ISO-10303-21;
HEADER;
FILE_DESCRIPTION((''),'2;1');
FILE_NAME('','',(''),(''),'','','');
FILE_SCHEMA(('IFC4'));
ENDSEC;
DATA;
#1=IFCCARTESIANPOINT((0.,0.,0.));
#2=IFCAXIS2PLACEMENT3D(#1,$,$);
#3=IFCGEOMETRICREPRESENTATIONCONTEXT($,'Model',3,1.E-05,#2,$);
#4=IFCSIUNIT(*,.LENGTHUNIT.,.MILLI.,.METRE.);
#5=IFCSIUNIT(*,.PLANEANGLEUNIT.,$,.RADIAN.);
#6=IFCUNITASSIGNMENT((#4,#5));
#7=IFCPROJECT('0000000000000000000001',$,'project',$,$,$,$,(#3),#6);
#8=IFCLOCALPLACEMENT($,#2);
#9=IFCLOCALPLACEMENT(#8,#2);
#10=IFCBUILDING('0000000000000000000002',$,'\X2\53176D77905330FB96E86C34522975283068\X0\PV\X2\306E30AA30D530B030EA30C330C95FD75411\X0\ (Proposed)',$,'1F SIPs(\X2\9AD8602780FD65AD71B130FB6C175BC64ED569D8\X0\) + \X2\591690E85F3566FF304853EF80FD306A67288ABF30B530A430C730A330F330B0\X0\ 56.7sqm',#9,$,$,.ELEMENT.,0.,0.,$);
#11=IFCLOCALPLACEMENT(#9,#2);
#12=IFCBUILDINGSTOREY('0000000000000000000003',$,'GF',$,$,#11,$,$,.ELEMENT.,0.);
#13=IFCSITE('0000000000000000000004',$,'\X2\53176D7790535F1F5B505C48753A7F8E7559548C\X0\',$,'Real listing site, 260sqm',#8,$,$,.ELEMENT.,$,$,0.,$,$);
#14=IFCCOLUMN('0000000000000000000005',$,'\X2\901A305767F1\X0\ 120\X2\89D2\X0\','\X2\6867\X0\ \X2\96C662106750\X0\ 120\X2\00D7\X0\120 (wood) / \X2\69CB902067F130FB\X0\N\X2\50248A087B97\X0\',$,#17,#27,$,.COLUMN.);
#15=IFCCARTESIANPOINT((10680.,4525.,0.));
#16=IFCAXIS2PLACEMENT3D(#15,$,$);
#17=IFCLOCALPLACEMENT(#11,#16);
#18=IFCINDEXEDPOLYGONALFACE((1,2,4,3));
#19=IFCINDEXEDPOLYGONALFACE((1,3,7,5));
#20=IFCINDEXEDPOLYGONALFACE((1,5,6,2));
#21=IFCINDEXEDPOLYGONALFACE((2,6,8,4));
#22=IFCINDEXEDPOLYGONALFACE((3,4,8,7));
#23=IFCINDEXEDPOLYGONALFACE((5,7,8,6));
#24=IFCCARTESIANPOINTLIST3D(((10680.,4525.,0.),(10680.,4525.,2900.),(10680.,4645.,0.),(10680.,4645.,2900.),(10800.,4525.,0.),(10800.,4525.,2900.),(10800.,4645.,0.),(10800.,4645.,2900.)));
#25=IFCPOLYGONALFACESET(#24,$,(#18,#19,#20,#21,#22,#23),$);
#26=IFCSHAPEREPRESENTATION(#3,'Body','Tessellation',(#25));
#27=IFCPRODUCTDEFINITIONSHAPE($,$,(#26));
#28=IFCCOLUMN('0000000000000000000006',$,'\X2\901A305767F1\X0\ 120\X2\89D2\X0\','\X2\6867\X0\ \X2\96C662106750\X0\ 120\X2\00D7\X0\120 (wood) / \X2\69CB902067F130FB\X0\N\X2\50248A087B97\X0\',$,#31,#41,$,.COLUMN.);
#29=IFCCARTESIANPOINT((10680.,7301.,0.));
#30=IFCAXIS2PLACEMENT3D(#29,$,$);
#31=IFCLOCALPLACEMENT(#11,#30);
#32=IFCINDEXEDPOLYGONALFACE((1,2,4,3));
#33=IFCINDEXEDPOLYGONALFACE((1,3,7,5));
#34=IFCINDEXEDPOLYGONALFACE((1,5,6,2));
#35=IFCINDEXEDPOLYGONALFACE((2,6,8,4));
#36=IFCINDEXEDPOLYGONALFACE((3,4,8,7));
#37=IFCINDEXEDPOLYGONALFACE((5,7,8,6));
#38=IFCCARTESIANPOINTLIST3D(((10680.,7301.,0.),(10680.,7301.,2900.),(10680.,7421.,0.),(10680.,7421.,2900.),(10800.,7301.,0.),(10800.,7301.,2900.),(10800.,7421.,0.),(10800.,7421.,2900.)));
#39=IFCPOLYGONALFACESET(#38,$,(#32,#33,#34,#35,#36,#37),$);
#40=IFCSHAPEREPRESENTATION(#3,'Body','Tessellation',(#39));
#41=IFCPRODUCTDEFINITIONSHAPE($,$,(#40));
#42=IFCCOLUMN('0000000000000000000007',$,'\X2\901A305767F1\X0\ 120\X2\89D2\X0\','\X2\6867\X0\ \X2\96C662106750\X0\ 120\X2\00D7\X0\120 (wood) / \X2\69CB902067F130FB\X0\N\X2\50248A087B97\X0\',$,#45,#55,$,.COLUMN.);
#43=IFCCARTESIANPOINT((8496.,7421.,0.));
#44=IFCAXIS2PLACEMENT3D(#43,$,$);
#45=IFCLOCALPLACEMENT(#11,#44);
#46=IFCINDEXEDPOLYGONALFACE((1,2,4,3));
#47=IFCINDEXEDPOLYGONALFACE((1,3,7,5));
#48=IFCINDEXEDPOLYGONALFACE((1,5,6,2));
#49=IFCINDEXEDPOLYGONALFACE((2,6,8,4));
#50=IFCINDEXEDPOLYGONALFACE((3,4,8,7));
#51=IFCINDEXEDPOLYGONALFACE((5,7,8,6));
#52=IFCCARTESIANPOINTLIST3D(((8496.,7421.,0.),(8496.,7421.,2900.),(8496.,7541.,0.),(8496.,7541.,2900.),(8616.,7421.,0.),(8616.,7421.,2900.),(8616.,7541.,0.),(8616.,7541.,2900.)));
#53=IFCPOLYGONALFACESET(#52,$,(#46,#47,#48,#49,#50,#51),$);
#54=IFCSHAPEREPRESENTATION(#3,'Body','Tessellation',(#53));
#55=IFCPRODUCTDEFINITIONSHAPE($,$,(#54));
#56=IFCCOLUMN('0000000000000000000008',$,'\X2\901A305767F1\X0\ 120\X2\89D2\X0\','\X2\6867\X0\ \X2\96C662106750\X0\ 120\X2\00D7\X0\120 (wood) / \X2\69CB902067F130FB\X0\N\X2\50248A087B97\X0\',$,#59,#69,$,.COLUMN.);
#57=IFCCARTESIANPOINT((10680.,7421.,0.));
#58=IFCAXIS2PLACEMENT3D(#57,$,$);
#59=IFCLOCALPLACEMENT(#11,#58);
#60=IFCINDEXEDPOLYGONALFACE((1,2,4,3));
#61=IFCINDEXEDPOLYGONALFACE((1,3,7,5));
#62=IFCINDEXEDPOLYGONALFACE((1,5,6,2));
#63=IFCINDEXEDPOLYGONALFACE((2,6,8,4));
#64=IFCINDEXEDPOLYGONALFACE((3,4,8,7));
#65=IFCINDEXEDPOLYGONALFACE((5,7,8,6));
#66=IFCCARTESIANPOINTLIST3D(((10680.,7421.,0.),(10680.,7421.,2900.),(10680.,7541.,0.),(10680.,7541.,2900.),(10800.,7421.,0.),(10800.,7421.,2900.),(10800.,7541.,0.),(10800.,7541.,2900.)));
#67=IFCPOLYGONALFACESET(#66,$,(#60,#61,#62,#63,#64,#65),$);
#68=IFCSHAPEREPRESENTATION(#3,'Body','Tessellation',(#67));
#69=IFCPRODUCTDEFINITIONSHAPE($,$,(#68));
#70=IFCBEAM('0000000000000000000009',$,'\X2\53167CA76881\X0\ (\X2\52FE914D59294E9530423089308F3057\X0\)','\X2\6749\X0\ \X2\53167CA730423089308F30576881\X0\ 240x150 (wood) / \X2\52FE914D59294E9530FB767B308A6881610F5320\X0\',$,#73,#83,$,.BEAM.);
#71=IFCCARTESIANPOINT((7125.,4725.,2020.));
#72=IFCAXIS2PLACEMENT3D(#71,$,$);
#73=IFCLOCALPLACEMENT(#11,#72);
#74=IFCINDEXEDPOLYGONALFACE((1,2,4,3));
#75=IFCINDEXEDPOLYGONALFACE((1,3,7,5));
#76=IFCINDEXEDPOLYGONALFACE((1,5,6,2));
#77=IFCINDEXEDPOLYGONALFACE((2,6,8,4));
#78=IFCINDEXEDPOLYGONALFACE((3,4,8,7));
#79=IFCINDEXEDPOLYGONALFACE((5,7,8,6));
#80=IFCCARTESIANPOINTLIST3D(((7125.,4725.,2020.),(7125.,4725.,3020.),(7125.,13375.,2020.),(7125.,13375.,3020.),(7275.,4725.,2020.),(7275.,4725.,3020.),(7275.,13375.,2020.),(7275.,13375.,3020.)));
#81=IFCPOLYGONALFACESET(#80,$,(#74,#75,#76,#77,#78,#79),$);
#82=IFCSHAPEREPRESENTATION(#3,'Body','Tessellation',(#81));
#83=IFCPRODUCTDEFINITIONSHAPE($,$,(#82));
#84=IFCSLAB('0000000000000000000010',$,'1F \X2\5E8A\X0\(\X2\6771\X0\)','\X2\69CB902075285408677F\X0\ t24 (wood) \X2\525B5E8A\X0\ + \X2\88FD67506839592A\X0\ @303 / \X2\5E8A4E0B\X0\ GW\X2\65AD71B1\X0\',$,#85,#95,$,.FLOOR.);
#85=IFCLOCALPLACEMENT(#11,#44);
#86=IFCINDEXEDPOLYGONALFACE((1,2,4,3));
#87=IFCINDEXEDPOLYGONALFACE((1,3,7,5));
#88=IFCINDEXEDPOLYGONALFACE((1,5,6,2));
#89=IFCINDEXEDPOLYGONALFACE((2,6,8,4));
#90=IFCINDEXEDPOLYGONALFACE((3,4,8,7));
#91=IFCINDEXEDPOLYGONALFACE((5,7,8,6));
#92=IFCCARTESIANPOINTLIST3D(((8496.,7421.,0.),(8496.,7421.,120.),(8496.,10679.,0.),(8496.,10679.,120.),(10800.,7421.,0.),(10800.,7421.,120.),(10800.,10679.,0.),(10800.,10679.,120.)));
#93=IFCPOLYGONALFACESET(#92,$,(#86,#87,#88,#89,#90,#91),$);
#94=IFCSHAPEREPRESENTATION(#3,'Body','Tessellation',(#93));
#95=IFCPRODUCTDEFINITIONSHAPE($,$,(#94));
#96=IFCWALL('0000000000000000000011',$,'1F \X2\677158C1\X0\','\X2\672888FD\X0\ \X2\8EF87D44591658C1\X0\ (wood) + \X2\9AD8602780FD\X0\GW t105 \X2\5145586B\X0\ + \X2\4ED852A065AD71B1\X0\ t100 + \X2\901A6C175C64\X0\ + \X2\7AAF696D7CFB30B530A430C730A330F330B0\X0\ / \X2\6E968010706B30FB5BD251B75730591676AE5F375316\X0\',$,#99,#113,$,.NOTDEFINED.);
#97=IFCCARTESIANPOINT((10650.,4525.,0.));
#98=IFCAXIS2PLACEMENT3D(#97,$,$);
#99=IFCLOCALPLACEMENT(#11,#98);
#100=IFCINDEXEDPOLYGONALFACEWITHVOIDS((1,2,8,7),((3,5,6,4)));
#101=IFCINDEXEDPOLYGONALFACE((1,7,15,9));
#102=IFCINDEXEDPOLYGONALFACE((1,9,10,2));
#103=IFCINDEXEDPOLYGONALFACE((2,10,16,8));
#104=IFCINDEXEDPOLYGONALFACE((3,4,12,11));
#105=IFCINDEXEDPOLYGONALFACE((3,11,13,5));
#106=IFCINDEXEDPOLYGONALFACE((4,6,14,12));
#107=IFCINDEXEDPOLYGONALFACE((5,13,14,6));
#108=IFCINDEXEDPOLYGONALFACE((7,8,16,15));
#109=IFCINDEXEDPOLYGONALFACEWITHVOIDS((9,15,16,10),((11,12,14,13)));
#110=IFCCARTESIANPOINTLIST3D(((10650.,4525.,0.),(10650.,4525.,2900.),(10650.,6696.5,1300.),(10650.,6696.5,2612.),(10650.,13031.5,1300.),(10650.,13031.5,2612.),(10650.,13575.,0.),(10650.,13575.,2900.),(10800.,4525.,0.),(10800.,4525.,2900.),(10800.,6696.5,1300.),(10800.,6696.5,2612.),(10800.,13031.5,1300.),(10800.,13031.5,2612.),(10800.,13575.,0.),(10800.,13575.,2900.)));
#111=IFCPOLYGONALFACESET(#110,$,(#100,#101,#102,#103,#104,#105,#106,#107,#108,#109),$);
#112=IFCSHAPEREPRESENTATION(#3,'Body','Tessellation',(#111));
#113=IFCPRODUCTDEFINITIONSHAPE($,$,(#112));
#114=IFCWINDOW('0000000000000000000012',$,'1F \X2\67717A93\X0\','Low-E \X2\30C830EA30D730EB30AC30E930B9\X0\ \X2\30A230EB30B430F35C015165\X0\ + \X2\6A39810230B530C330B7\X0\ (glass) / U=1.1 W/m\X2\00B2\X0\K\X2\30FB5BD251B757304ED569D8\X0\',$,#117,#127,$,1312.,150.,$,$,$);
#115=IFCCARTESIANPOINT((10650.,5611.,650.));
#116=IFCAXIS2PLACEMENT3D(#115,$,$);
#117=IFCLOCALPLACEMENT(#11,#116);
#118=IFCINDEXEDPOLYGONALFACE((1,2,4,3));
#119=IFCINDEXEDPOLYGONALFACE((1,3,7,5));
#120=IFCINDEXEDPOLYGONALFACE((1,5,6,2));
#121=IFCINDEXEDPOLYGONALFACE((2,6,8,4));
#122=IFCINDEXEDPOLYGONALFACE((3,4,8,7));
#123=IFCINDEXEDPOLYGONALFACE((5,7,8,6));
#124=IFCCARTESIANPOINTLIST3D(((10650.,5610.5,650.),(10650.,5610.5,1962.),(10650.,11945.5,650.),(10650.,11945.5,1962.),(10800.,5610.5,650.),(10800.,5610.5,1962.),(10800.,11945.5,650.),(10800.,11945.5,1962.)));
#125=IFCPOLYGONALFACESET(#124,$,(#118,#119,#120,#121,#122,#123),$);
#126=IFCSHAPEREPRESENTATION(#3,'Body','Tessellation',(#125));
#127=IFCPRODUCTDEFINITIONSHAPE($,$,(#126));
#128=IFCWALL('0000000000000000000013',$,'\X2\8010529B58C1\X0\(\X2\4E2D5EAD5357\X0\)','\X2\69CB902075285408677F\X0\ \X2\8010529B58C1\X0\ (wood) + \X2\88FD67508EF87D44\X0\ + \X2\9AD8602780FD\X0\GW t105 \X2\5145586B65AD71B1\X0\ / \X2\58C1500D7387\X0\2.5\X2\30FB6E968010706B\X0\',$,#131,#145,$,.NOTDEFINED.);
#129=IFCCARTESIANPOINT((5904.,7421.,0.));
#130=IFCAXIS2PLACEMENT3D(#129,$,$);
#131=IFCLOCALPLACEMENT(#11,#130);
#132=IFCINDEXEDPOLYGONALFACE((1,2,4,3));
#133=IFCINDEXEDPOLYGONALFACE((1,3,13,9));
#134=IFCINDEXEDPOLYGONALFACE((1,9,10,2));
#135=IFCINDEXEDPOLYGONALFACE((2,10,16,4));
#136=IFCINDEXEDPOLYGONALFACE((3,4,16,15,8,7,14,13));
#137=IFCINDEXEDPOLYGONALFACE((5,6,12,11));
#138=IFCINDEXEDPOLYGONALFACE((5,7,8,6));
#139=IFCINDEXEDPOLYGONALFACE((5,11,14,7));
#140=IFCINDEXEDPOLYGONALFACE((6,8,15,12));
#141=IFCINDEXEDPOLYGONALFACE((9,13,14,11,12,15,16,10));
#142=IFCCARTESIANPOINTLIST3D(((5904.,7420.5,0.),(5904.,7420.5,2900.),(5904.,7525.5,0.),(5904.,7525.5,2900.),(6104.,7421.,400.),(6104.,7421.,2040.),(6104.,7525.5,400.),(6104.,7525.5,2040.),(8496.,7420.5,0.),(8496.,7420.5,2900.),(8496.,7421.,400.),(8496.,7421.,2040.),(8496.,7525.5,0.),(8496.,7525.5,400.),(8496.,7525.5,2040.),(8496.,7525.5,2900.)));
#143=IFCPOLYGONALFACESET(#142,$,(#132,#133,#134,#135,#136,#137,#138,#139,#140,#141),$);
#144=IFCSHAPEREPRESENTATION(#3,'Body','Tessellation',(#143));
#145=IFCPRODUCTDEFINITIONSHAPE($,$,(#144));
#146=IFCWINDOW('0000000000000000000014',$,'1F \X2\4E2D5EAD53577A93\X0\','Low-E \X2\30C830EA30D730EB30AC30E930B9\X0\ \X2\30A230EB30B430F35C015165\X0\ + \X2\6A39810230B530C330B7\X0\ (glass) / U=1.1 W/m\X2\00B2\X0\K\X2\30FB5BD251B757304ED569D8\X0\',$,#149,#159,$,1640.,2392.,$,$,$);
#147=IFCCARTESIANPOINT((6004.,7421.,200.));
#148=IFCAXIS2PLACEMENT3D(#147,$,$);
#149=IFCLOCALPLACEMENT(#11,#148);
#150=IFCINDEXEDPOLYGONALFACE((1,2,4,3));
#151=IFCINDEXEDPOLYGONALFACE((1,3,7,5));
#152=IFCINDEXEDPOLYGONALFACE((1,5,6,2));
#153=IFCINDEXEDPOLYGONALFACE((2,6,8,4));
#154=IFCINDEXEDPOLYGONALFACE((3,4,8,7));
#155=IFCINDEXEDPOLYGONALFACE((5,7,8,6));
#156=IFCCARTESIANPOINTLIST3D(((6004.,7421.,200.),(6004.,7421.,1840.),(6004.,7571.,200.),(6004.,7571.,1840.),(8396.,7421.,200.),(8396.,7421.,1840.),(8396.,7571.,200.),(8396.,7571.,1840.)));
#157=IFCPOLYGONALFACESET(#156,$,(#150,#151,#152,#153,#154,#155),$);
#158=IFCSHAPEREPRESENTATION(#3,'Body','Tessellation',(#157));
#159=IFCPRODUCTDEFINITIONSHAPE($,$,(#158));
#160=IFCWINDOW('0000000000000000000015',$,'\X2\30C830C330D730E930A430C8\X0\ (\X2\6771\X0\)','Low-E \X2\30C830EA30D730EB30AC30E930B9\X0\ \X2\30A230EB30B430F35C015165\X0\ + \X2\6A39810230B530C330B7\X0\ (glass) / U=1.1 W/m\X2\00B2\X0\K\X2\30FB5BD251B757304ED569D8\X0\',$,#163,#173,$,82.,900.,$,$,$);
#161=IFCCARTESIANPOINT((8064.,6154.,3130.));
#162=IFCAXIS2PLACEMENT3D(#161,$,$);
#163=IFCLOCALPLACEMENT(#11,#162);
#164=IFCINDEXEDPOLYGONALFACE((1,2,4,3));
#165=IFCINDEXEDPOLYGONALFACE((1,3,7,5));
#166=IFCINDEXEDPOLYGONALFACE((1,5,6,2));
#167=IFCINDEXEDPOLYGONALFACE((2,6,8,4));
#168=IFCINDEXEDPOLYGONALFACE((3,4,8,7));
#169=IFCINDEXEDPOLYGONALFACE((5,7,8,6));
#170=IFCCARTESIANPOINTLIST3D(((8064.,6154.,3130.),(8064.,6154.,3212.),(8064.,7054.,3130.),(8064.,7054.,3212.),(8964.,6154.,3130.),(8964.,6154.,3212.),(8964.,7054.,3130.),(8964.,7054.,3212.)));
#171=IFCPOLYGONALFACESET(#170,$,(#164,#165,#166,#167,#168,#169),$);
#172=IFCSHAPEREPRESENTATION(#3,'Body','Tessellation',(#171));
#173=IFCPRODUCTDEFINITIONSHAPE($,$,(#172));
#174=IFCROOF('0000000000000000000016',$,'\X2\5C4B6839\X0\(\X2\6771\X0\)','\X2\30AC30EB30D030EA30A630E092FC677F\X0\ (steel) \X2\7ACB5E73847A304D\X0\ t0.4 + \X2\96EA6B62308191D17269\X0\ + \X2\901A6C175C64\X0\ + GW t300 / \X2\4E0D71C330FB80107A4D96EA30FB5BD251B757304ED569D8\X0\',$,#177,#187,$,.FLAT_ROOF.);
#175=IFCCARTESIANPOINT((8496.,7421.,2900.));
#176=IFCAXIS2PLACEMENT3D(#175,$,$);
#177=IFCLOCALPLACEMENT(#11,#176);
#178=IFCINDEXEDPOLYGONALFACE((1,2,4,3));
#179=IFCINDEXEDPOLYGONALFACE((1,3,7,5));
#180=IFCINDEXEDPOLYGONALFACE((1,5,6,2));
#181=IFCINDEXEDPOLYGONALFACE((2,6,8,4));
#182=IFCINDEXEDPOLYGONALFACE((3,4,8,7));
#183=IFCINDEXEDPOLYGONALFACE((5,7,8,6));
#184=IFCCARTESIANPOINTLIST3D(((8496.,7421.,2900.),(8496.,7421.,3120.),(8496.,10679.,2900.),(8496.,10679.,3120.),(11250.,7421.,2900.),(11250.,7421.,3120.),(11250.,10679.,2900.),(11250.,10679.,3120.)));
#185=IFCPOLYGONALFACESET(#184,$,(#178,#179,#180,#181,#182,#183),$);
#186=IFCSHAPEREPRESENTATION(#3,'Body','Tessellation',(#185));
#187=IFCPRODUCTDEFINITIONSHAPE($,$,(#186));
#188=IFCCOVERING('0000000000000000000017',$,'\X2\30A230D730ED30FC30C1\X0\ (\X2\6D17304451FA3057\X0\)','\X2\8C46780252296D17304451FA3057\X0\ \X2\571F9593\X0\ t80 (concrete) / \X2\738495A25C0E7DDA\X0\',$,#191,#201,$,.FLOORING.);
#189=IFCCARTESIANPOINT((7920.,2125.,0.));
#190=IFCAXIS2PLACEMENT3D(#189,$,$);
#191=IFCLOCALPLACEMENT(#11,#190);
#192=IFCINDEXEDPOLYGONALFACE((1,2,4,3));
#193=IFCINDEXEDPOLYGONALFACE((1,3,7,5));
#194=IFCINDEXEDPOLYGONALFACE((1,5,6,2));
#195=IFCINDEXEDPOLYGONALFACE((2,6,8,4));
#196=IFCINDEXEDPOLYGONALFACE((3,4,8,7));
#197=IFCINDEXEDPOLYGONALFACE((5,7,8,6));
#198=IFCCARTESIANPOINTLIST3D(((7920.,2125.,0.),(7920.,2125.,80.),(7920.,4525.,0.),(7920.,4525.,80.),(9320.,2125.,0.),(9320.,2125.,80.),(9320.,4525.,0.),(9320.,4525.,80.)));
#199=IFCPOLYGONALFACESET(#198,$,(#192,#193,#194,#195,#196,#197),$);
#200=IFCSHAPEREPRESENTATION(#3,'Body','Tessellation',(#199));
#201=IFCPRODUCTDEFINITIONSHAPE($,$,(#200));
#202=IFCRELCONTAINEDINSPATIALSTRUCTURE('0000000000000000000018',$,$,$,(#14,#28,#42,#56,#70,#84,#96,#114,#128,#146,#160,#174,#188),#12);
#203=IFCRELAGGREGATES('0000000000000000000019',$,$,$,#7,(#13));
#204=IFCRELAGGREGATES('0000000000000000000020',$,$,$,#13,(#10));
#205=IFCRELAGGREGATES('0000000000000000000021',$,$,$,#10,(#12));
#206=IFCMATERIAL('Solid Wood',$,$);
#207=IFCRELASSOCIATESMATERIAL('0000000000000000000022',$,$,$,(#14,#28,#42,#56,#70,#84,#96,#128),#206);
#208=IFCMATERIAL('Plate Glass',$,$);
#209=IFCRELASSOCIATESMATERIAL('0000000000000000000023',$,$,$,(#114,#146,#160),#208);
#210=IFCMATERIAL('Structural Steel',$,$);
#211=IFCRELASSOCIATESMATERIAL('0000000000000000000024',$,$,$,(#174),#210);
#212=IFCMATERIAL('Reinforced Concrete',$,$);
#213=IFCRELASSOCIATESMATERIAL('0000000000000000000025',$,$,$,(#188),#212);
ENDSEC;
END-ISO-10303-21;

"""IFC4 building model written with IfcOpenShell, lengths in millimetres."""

from ifc_helpers import new_model, si_unit, frame, frame_2d, origin, place, context, project, spatial, rectangle, extrude, material, element, fill, save


model = new_model("IFC4")

# Units and contexts
model_context = context("Model", 3, precision=1e-05, world=origin())
ifc_project = project(units=[si_unit("LENGTHUNIT", "METRE", prefix="MILLI"), si_unit("PLANEANGLEUNIT", "RADIAN")], contexts=[model_context])

# Site, building, storey
site_placement = place(None, origin())
site = spatial("IfcSite", under=ifc_project, at=site_placement, Name="北海道弟子屈町美留和", ObjectType="Real listing site, 260sqm", CompositionType="ELEMENT", RefElevation=0.0)
building_placement = place(site_placement, origin())
building = spatial("IfcBuilding", under=site, at=building_placement, Name="北海道・雨水利用とPVのオフグリッド志向 (Proposed)", ObjectType="1F SIPs(高性能断熱・気密仕様) + 外部張替え可能な木調サイディング 56.7sqm", CompositionType="ELEMENT", ElevationOfRefHeight=0.0, ElevationOfTerrain=0.0)
storey_placement = place(building_placement, origin())
storey = spatial("IfcBuildingStorey", under=building, at=storey_placement, Name="GF", CompositionType="ELEMENT", Elevation=0.0)

# Columns
ifc_material_1 = material(Name="Solid Wood")
column_1_placement = place(storey_placement, frame((10680.0, 4525.0, 0.0)))
element("IfcColumn", 1, at=column_1_placement, inside=storey, material=ifc_material_1, Name="通し柱 120角", Description="桧 集成材 120×120 (wood) / 構造柱・N値計算", PredefinedType="COLUMN", context=model_context, shape_type="SweptSolid", body=[
    extrude(rectangle(XDim=120.0, YDim=120.0, at=frame_2d((60.0, 60.0))), frame((10680.0, 4525.0, 0.0)), (0.0, 0.0, 1.0), 2900.0),
])
column_2_placement = place(storey_placement, frame((10680.0, 7301.0, 0.0)))
element("IfcColumn", 2, at=column_2_placement, inside=storey, material=ifc_material_1, Name="通し柱 120角", Description="桧 集成材 120×120 (wood) / 構造柱・N値計算", PredefinedType="COLUMN", context=model_context, shape_type="SweptSolid", body=[
    extrude(rectangle(XDim=120.0, YDim=120.0, at=frame_2d((60.0, 60.0))), frame((10680.0, 7301.0, 0.0)), (0.0, 0.0, 1.0), 2900.0),
])
column_3_placement = place(storey_placement, frame((8496.0, 7421.0, 0.0)))
element("IfcColumn", 3, at=column_3_placement, inside=storey, material=ifc_material_1, Name="通し柱 120角", Description="桧 集成材 120×120 (wood) / 構造柱・N値計算", PredefinedType="COLUMN", context=model_context, shape_type="SweptSolid", body=[
    extrude(rectangle(XDim=120.0, YDim=120.0, at=frame_2d((60.0, 60.0))), frame((8496.0, 7421.0, 0.0)), (0.0, 0.0, 1.0), 2900.0),
])
column_4_placement = place(storey_placement, frame((10680.0, 7421.0, 0.0)))
element("IfcColumn", 4, at=column_4_placement, inside=storey, material=ifc_material_1, Name="通し柱 120角", Description="桧 集成材 120×120 (wood) / 構造柱・N値計算", PredefinedType="COLUMN", context=model_context, shape_type="SweptSolid", body=[
    extrude(rectangle(XDim=120.0, YDim=120.0, at=frame_2d((60.0, 60.0))), frame((10680.0, 7421.0, 0.0)), (0.0, 0.0, 1.0), 2900.0),
])

# Beam
beam_1_placement = place(storey_placement, frame((7125.0, 4725.0, 2020.0)))
element("IfcBeam", 5, at=beam_1_placement, inside=storey, material=ifc_material_1, Name="化粧梁 (勾配天井あらわし)", Description="杉 化粧あらわし梁 240x150 (wood) / 勾配天井・登り梁意匠", PredefinedType="BEAM", context=model_context, shape_type="SweptSolid", body=[
    extrude(rectangle(XDim=150.0, YDim=8650.0, at=frame_2d((75.0, 4325.0))), frame((7125.0, 4725.0, 2020.0)), (0.0, 0.0, 1.0), 1000.0),
])

# Slab
slab_placement = place(storey_placement, frame((8496.0, 7421.0, 0.0)))
element("IfcSlab", 6, at=slab_placement, inside=storey, material=ifc_material_1, Name="1F 床(東)", Description="構造用合板 t24 (wood) 剛床 + 製材根太 @303 / 床下 GW断熱", PredefinedType="FLOOR", context=model_context, shape_type="SweptSolid", body=[
    extrude(rectangle(XDim=2304.0, YDim=3258.0, at=frame_2d((1152.0, 1629.0))), frame((8496.0, 7421.0, 0.0)), (0.0, 0.0, 1.0), 120.0),
])

# Walls, openings, windows
wall_1_placement = place(storey_placement, frame((10650.0, 4525.0, 0.0)))
wall_1 = element("IfcWall", 7, at=wall_1_placement, inside=storey, material=ifc_material_1, Name="1F 東壁", Description="木製 軸組外壁 (wood) + 高性能GW t105 充填 + 付加断熱 t100 + 通気層 + 窯業系サイディング / 準耐火・寒冷地外皮強化", PredefinedType="NOTDEFINED", context=model_context, shape_type="SweptSolid", body=[
    extrude(rectangle(XDim=150.0, YDim=9050.0, at=frame_2d((75.0, 4525.0))), frame((10650.0, 4525.0, 0.0)), (0.0, 0.0, 1.0), 2900.0),
])
opening_1_placement = place(storey_placement, frame((10650.0, 5611.0, 650.0)))
opening_1 = element("IfcOpeningElement", 8, at=opening_1_placement, cuts=wall_1, PredefinedType="NOTDEFINED", context=model_context, shape_type="SweptSolid", body=[
    extrude(rectangle(XDim=150.0, YDim=6335.0, at=frame_2d((75.0, 3167.0))), frame((10650.0, 5611.0, 650.0)), (0.0, 0.0, 1.0), 1312.0),
])
ifc_material_2 = material(Name="Plate Glass")
window_1_placement = place(storey_placement, frame((10650.0, 5611.0, 650.0)))
window_1 = element("IfcWindow", 9, at=window_1_placement, inside=storey, material=ifc_material_2, Name="1F 東窓", Description="Low-E トリプルガラス アルゴン封入 + 樹脂サッシ (glass) / U=1.1 W/m²K・寒冷地仕様", OverallHeight=1312.0, OverallWidth=150.0, context=model_context, shape_type="SweptSolid", body=[
    extrude(rectangle(XDim=150.0, YDim=6335.0, at=frame_2d((75.0, 3167.0))), frame((10650.0, 5611.0, 650.0)), (0.0, 0.0, 1.0), 1312.0),
])
fill(opening_1, window_1)
wall_2_placement = place(storey_placement, frame((5904.0, 7421.0, 0.0)))
wall_2 = element("IfcWall", 10, at=wall_2_placement, inside=storey, material=ifc_material_1, Name="耐力壁(中庭南)", Description="構造用合板 耐力壁 (wood) + 製材軸組 + 高性能GW t105 充填断熱 / 壁倍率2.5・準耐火", PredefinedType="NOTDEFINED", context=model_context, shape_type="SweptSolid", body=[
    extrude(rectangle(XDim=2592.0, YDim=105.0, at=frame_2d((1296.0, 52.0))), frame((5904.0, 7421.0, 0.0)), (0.0, 0.0, 1.0), 2900.0),
])
opening_2_placement = place(storey_placement, frame((6004.0, 7421.0, 200.0)))
opening_2 = element("IfcOpeningElement", 11, at=opening_2_placement, cuts=wall_2, PredefinedType="NOTDEFINED", context=model_context, shape_type="SweptSolid", body=[
    extrude(rectangle(XDim=2392.0, YDim=150.0, at=frame_2d((1196.0, 75.0))), frame((6004.0, 7421.0, 200.0)), (0.0, 0.0, 1.0), 1640.0),
])
window_2_placement = place(storey_placement, frame((6004.0, 7421.0, 200.0)))
window_2 = element("IfcWindow", 12, at=window_2_placement, inside=storey, material=ifc_material_2, Name="1F 中庭南窓", Description="Low-E トリプルガラス アルゴン封入 + 樹脂サッシ (glass) / U=1.1 W/m²K・寒冷地仕様", OverallHeight=1640.0, OverallWidth=2392.0, context=model_context, shape_type="SweptSolid", body=[
    extrude(rectangle(XDim=2392.0, YDim=150.0, at=frame_2d((1196.0, 75.0))), frame((6004.0, 7421.0, 200.0)), (0.0, 0.0, 1.0), 1640.0),
])
fill(opening_2, window_2)

# Window
window_3_placement = place(storey_placement, frame((8064.0, 6154.0, 3130.0)))
element("IfcWindow", 13, at=window_3_placement, inside=storey, material=ifc_material_2, Name="トップライト (東)", Description="Low-E トリプルガラス アルゴン封入 + 樹脂サッシ (glass) / U=1.1 W/m²K・寒冷地仕様", OverallHeight=82.0, OverallWidth=900.0, context=model_context, shape_type="SweptSolid", body=[
    extrude(rectangle(XDim=900.0, YDim=900.0, at=frame_2d((450.0, 450.0))), frame((8064.0, 6154.0, 3130.0)), (0.0, 0.0, 1.0), 82.0),
])

# Roof
ifc_material_3 = material(Name="Structural Steel")
roof_placement = place(storey_placement, frame((8496.0, 7421.0, 2900.0)))
element("IfcRoof", 14, at=roof_placement, inside=storey, material=ifc_material_3, Name="屋根(東)", Description="ガルバリウム鋼板 (steel) 立平葺き t0.4 + 雪止め金物 + 通気層 + GW t300 / 不燃・耐積雪・寒冷地仕様", PredefinedType="FLAT_ROOF", context=model_context, shape_type="SweptSolid", body=[
    extrude(rectangle(XDim=2754.0, YDim=3258.0, at=frame_2d((1377.0, 1629.0))), frame((8496.0, 7421.0, 2900.0)), (0.0, 0.0, 1.0), 220.0),
])

# Covering
ifc_material_4 = material(Name="Reinforced Concrete")
covering_placement = place(storey_placement, frame((7920.0, 2125.0, 0.0)))
element("IfcCovering", 15, at=covering_placement, inside=storey, material=ifc_material_4, Name="アプローチ (洗い出し)", Description="豆砂利洗い出し 土間 t80 (concrete) / 玄関導線", PredefinedType="FLOORING", context=model_context, shape_type="SweptSolid", body=[
    extrude(rectangle(XDim=1400.0, YDim=2400.0, at=frame_2d((700.0, 1200.0))), frame((7920.0, 2125.0, 0.0)), (0.0, 0.0, 1.0), 80.0),
])

save(model, "model.ifc")
